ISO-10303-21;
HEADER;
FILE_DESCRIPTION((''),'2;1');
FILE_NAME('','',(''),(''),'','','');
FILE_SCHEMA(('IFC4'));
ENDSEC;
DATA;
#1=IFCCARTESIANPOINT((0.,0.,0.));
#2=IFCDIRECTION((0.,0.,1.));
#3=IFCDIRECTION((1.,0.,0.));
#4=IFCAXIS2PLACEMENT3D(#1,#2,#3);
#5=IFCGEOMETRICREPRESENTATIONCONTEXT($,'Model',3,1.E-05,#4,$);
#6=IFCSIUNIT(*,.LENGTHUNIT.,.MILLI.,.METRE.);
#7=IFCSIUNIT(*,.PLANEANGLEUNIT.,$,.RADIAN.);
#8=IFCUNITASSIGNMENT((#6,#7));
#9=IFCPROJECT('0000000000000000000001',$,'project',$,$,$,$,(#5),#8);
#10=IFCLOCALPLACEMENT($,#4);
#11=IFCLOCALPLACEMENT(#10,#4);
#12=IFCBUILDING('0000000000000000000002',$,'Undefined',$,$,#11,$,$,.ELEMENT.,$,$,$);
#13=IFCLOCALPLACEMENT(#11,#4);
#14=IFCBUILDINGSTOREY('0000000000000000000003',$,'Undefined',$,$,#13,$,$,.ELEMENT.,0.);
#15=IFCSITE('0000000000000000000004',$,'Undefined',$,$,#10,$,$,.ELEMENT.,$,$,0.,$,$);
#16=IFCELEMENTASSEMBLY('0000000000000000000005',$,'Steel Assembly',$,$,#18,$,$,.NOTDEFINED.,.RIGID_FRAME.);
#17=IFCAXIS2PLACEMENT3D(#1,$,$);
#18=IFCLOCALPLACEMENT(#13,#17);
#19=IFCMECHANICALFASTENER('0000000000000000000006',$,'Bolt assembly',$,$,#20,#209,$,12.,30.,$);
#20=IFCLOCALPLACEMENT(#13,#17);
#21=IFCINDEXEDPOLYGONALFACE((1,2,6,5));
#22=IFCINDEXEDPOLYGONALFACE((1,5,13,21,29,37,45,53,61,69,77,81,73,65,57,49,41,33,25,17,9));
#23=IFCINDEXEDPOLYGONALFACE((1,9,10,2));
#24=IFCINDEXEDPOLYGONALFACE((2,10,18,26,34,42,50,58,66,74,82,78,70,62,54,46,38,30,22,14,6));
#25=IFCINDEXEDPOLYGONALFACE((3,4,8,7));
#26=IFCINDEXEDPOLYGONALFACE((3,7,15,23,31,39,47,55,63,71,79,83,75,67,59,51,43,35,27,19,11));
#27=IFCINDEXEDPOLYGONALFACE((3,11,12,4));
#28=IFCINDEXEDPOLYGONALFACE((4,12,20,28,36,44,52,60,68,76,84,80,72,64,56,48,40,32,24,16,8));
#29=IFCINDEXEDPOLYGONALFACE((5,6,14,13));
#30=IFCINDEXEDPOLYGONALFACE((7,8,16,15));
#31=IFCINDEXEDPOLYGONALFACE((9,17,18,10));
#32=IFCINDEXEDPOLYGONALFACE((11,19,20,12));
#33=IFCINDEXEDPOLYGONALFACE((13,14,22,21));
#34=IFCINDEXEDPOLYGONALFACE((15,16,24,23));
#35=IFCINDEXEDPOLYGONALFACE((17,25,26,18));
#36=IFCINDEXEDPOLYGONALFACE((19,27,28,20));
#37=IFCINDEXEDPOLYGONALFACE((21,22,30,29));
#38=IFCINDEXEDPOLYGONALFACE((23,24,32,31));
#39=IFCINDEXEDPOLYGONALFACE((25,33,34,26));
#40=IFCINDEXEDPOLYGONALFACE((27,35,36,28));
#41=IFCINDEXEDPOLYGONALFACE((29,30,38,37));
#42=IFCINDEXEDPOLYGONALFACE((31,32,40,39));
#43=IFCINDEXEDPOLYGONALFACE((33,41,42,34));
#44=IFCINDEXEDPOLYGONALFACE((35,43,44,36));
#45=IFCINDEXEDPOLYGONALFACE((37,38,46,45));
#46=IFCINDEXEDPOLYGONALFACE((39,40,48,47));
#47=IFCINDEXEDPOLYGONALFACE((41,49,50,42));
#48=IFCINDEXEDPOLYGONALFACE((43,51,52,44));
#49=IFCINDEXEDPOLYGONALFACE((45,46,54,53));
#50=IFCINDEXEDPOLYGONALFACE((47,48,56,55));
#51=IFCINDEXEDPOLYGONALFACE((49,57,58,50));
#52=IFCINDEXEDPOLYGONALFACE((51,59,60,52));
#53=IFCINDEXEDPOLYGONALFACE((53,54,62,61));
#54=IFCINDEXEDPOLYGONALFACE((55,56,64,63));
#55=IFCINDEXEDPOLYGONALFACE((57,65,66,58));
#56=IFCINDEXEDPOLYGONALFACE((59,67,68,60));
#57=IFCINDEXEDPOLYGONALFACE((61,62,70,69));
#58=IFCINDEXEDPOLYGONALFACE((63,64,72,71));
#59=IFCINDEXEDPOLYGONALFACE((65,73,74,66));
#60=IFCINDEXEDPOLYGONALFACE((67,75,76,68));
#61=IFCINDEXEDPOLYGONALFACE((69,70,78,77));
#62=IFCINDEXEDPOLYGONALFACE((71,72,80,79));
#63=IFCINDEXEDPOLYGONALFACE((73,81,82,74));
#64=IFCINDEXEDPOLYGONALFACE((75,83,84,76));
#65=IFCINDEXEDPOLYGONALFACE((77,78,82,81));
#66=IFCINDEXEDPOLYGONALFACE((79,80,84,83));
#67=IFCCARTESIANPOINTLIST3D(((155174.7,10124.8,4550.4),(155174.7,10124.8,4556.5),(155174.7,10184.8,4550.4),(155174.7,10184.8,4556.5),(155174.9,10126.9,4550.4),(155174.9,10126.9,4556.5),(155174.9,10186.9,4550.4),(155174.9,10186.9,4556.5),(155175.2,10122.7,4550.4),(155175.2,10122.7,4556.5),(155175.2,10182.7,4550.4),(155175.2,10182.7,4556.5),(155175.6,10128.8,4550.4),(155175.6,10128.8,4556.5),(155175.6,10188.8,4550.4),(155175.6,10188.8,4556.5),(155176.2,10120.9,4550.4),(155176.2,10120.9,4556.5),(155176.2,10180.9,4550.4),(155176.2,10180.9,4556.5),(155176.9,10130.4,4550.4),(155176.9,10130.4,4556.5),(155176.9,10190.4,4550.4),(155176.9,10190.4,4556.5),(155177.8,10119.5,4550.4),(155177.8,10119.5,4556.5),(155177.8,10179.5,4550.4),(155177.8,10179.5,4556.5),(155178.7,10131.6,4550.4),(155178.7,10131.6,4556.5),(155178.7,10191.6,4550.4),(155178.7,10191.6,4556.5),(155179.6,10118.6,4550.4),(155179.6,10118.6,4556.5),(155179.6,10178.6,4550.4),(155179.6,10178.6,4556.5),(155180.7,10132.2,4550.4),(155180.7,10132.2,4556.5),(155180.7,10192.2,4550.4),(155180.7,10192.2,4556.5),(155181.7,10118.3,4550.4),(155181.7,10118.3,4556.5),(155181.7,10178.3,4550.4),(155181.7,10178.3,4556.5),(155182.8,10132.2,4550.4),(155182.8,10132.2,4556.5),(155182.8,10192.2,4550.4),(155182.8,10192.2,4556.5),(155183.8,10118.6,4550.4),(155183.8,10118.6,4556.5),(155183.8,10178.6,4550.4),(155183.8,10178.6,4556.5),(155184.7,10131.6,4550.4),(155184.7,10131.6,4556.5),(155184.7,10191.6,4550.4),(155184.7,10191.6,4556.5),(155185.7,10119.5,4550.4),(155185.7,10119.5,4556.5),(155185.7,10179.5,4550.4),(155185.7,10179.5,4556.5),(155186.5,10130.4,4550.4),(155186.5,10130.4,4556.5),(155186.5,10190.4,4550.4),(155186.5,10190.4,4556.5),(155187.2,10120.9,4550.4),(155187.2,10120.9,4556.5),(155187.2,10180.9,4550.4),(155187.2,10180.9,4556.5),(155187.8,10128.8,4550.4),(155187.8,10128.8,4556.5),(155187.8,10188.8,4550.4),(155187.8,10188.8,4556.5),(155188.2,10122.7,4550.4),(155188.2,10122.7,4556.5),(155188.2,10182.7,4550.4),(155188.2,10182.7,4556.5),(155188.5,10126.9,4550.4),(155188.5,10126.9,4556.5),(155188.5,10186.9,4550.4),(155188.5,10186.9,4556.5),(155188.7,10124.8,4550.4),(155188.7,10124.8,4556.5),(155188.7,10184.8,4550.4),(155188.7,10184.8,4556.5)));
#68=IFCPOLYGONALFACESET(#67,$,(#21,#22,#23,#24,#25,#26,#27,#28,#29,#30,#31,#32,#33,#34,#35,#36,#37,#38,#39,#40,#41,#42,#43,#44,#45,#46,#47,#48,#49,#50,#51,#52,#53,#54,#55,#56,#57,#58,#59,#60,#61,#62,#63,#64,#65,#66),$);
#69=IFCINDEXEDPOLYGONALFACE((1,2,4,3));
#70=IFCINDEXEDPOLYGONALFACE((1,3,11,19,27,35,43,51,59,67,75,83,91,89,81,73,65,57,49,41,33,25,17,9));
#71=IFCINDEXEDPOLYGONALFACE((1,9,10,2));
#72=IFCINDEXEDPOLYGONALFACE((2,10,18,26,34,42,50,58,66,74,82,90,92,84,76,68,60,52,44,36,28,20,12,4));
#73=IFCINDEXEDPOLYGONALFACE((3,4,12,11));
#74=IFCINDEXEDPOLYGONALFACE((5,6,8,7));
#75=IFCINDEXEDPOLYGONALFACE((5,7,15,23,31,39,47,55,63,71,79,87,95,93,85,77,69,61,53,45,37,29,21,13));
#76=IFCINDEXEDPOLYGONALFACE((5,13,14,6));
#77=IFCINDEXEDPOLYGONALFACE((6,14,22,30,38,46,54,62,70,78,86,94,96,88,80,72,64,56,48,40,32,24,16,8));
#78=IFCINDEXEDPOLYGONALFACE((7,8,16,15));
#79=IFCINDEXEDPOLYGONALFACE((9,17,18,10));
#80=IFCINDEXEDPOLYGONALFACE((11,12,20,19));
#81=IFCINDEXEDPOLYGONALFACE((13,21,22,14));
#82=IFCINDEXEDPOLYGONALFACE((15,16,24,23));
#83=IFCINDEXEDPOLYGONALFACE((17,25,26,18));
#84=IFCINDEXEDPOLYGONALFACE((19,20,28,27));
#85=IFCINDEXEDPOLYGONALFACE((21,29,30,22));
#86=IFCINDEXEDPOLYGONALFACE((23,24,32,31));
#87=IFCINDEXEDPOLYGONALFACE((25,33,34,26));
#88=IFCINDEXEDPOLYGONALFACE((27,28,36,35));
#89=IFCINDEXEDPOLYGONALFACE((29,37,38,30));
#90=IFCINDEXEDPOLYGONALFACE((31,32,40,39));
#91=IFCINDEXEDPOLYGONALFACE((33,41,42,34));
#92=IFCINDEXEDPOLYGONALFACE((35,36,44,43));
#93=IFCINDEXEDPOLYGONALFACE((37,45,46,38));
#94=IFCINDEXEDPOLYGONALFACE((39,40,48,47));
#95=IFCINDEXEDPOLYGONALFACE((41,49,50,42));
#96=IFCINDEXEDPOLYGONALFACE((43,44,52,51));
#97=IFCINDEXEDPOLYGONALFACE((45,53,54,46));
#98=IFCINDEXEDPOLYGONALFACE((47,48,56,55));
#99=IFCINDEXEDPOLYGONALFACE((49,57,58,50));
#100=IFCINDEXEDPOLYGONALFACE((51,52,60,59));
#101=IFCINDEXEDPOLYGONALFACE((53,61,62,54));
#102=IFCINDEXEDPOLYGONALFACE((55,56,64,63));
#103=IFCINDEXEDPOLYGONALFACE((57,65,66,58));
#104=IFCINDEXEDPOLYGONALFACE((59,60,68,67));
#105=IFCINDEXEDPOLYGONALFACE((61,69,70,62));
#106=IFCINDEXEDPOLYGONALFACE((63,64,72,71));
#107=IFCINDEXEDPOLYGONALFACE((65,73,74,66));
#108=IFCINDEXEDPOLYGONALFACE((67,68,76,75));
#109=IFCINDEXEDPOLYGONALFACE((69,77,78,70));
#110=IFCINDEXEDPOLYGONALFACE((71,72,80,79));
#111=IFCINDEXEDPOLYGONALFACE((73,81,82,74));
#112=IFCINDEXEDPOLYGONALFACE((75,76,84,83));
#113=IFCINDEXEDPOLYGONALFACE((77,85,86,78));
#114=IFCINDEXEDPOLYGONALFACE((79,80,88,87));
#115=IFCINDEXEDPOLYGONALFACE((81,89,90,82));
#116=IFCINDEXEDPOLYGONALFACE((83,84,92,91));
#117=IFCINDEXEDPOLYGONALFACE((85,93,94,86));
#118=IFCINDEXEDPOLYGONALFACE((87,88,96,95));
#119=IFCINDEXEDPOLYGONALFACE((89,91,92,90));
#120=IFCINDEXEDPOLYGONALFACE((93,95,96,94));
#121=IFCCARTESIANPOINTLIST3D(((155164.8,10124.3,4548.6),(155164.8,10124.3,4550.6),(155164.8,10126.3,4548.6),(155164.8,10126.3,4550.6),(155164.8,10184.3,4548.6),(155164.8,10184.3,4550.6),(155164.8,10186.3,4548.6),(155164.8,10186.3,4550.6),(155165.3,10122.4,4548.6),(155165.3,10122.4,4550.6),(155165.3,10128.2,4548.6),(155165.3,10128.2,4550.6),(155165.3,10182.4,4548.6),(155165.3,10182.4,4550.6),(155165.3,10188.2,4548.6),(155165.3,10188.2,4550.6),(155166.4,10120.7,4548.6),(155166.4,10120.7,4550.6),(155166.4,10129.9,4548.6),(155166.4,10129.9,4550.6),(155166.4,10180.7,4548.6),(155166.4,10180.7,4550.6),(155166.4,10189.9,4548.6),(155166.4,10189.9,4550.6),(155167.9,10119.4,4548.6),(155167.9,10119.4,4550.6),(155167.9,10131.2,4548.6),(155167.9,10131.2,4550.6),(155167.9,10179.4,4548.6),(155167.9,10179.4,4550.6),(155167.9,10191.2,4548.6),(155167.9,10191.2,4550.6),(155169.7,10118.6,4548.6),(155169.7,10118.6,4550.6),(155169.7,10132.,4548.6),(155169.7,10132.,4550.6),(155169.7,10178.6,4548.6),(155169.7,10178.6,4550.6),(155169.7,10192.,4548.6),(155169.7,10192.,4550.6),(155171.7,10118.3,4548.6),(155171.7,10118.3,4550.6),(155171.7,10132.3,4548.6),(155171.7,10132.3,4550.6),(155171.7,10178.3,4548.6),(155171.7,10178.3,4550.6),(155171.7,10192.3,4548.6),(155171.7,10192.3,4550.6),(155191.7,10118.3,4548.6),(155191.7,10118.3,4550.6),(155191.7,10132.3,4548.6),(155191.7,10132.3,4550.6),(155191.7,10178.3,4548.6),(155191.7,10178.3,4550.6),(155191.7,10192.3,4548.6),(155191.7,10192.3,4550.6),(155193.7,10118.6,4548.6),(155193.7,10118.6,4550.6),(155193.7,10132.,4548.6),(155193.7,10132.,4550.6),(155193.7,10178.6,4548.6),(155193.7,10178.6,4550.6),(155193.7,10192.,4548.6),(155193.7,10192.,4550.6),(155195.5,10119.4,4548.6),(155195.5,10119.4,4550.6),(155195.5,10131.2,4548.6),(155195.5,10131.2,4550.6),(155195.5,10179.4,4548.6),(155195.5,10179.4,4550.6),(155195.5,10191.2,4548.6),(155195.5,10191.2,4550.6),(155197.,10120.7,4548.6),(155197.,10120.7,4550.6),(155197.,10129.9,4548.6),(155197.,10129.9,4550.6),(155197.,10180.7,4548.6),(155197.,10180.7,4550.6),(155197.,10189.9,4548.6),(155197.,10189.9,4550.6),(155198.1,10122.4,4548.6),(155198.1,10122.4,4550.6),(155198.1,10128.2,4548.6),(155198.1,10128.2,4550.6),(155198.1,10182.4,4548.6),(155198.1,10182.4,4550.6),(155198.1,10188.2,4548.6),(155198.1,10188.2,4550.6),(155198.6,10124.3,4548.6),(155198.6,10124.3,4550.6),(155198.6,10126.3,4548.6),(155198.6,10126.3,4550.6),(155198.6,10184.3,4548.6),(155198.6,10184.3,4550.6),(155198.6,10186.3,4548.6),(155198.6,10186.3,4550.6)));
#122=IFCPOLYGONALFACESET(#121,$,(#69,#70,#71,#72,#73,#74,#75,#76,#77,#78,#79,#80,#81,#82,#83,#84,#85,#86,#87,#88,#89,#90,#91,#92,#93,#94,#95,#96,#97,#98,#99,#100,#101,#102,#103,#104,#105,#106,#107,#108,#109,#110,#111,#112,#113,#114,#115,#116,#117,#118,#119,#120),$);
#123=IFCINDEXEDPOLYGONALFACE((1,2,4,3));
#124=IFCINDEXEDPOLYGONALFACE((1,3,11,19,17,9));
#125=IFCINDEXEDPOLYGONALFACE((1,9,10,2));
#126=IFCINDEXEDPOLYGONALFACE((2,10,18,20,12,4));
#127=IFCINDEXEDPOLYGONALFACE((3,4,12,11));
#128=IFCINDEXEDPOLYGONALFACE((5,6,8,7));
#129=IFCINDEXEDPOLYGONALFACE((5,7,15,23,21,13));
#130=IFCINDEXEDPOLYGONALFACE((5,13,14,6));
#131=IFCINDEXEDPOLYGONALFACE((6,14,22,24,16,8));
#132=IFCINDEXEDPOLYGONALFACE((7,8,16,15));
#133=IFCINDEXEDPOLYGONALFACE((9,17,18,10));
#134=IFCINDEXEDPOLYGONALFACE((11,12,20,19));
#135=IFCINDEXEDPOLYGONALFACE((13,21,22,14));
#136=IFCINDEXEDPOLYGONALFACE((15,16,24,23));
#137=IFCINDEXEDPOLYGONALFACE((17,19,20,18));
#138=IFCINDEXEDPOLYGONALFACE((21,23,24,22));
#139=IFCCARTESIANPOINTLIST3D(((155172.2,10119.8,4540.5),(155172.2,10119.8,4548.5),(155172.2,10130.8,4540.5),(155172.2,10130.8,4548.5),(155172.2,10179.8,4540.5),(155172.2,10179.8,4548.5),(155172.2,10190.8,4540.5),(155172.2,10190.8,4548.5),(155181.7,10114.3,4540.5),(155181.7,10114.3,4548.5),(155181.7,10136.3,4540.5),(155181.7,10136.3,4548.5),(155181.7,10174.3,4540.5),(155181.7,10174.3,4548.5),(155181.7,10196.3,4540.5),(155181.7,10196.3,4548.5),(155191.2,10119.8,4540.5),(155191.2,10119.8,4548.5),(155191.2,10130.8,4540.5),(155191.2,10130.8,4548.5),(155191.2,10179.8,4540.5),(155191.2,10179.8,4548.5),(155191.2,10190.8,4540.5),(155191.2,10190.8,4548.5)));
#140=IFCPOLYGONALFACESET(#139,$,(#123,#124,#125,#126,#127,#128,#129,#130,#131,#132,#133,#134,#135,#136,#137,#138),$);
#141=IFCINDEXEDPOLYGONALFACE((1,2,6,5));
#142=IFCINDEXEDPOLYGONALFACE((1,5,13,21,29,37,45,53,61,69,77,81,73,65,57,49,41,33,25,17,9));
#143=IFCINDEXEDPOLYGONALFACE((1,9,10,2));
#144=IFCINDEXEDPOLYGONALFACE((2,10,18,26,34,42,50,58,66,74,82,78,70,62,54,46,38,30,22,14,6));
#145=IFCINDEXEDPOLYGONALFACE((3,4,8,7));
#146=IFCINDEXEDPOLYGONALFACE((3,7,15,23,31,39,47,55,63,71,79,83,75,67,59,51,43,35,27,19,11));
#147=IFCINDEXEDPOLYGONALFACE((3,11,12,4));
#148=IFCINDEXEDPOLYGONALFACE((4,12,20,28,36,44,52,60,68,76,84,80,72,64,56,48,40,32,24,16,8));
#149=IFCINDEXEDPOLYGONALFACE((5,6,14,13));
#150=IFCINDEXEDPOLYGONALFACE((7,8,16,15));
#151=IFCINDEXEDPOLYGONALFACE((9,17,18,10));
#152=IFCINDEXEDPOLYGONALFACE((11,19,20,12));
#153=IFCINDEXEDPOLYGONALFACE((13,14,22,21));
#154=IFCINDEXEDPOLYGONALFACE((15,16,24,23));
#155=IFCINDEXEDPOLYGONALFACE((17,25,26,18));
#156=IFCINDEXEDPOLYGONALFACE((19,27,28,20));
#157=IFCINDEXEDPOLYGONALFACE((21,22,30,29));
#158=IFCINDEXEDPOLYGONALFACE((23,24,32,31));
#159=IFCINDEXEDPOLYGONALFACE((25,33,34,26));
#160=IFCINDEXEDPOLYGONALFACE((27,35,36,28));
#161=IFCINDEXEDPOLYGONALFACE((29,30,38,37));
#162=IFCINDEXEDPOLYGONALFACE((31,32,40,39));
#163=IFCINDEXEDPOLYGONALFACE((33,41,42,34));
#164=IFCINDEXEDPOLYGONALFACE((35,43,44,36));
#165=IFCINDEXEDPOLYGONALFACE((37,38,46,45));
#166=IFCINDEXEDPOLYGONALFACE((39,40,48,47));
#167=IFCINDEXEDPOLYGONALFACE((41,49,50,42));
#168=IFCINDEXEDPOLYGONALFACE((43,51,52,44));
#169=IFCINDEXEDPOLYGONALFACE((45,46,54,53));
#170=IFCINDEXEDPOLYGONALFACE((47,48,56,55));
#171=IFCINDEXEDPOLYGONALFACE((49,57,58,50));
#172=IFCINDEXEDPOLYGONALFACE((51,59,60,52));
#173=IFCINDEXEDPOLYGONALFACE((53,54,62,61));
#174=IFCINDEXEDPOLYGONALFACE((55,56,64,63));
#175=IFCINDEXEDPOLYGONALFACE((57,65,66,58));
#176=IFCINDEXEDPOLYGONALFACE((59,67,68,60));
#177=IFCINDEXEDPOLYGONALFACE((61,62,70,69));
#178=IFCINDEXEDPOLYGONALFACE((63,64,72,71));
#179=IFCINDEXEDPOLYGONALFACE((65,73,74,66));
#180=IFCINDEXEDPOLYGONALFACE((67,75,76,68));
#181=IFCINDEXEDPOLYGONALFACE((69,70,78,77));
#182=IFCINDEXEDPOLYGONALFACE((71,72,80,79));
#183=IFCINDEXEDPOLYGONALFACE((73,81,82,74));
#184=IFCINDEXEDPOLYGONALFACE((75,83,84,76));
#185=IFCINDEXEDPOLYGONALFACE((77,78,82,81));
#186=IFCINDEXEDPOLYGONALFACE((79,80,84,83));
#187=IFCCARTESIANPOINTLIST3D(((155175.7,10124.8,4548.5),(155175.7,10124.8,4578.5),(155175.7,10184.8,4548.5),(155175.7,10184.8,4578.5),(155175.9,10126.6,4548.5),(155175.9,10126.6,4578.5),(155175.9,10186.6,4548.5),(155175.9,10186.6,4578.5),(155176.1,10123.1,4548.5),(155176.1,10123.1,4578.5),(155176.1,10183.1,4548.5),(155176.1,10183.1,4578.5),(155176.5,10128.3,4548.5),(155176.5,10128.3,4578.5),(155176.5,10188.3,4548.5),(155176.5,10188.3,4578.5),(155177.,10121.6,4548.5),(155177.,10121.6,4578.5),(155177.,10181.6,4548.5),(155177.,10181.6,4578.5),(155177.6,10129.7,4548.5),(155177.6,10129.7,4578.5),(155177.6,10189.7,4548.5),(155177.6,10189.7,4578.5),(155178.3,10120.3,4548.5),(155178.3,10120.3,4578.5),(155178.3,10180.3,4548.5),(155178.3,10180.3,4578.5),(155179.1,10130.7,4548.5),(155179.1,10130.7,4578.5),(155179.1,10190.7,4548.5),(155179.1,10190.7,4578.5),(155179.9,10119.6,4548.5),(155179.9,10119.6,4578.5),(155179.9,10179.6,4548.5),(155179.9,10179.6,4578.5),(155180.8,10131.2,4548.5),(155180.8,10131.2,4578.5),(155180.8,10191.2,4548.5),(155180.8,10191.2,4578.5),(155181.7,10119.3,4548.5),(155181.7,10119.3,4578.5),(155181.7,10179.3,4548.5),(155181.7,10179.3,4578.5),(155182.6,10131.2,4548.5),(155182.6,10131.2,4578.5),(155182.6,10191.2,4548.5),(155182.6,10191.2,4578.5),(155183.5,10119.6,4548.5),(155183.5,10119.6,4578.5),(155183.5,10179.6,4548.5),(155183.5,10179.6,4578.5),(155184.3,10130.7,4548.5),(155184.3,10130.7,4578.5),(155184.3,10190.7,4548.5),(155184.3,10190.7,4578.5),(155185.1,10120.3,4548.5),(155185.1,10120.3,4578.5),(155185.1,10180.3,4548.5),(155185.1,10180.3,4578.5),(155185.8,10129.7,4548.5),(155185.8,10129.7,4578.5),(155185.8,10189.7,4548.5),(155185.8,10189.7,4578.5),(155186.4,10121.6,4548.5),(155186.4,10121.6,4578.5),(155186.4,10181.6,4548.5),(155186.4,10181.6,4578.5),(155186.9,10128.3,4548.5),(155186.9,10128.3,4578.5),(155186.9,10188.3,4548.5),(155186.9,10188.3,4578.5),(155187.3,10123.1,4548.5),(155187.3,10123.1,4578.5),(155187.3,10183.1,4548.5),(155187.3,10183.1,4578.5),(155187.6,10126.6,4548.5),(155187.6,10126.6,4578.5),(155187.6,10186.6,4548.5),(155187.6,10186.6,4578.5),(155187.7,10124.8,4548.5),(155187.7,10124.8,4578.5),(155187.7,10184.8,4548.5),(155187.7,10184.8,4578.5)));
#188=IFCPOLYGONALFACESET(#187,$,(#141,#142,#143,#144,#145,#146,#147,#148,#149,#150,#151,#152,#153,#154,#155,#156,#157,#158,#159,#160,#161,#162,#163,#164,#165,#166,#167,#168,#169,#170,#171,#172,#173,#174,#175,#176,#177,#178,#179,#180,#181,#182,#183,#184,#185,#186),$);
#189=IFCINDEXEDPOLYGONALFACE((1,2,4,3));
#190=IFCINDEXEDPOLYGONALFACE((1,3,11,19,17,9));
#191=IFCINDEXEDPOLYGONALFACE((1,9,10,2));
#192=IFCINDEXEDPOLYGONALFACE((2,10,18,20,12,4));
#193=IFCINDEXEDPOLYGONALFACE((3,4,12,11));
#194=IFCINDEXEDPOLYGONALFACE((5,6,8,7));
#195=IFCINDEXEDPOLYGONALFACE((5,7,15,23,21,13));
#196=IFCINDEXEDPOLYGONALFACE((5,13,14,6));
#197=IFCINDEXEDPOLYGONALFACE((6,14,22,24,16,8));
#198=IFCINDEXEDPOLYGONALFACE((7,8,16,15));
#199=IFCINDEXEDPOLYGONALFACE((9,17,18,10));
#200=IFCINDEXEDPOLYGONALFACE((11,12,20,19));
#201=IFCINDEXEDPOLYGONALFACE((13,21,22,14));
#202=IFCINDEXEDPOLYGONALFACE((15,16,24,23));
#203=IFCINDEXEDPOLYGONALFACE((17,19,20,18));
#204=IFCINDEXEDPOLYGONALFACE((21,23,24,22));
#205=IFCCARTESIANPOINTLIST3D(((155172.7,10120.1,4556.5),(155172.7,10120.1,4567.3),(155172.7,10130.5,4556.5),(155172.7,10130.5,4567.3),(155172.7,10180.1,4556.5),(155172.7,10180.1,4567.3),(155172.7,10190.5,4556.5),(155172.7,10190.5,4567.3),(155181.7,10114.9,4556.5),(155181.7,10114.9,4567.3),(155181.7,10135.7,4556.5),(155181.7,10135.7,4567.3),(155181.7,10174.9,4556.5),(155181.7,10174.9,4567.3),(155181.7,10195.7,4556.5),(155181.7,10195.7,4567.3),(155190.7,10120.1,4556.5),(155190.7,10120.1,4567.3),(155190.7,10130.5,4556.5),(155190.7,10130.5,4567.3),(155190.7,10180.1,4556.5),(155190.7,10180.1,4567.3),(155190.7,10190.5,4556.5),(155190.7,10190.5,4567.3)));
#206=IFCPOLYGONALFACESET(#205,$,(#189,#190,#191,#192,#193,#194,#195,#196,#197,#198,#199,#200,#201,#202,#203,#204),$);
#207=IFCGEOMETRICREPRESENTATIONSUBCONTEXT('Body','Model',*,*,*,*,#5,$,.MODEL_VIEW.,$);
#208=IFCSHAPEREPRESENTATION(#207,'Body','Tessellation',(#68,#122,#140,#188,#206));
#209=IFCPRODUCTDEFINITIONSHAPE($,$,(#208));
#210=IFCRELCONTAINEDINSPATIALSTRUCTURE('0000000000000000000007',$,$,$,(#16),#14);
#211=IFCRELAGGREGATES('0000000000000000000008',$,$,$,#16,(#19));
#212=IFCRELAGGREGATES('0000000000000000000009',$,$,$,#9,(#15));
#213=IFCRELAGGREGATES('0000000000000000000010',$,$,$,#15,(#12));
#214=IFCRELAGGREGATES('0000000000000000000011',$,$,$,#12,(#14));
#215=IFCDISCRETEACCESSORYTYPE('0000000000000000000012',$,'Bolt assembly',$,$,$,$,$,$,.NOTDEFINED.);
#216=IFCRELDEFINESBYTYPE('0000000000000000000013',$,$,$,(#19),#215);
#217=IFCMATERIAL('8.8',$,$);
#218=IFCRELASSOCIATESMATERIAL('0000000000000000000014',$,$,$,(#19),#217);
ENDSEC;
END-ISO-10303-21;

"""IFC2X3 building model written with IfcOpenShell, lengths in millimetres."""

from ifc_helpers import new_model, si_unit, frame, frame_2d, origin_with_axes, origin_2d_with_axis, place, context, subcontext, project, spatial, polyline, circle_curve, parameter, trimmed, segment, composite_curve, circle, outline, extrude, source, transform, mapped, material, type_object, element, aggregate, save


model = new_model("IFC2X3")

# Units and contexts
model_context = context("Model", 3, precision=1e-05, world=origin_with_axes())
body_context = subcontext(model_context, "Body", "Model", "MODEL_VIEW")
ifc_project = project(units=[si_unit("LENGTHUNIT", "METRE", prefix="MILLI"), si_unit("PLANEANGLEUNIT", "RADIAN")], contexts=[model_context])

# Site, building, storey
site_placement = place(None, origin_with_axes())
site = spatial("IfcSite", under=ifc_project, at=site_placement, Name="Undefined", CompositionType="ELEMENT", RefElevation=0.0)
building_placement = place(site_placement, origin_with_axes())
building = spatial("IfcBuilding", under=site, at=building_placement, Name="Undefined", CompositionType="ELEMENT")
storey_placement = place(building_placement, origin_with_axes())
storey = spatial("IfcBuildingStorey", under=building, at=storey_placement, Name="Undefined", CompositionType="ELEMENT", Elevation=0.0)

# Shared definitions
discrete_accessory_type_1 = type_object("IfcDiscreteAccessoryType", Name="Bolt assembly")

# Shared definitions
ifc_material_1 = material(Name="8.8")

# Element assembly, mechanical fastener
assembly_1_placement = place(storey_placement, origin_with_axes())
assembly_1 = element("IfcElementAssembly", 1, at=assembly_1_placement, inside=storey, Name="Steel Assembly", AssemblyPlace="NOTDEFINED", PredefinedType="RIGID_FRAME")
shared_shape_1 = source(origin_with_axes(), body_context, "Body", "SweptSolid", [
    extrude(circle(Radius=7.0, at=origin_2d_with_axis()), frame((0.0, -3.1, 0.0), z_axis=(0.0, 1.0, 0.0), x_axis=(1.0, 0.0, 0.0)), (0.0, 0.0, 1.0), 6.1),
    extrude(outline(composite_curve([segment(polyline([(7.0, 10.0), (7.0, -10.0)]), True, "CONTINUOUS"), segment(trimmed(circle_curve(frame_2d((0.0, -10.0), x_axis=(1.0, 0.0)), 7.0), [parameter(0.0)], [parameter(3.1416)], False, "PARAMETER"), True, "CONTINUOUS"), segment(polyline([(-7.0, -10.0), (-7.0, 10.0)]), True, "CONTINUOUS"), segment(trimmed(circle_curve(frame_2d((0.0, 10.0), x_axis=(-1.0, 0.0)), 7.0), [parameter(0.0)], [parameter(3.1416)], False, "PARAMETER"), True, "DISCONTINUOUS")], self_intersect=False)), frame((0.0, -4.9, 0.0), z_axis=(0.0, 1.0, 0.0), x_axis=(1.0, 0.0, 0.0)), (0.0, 0.0, 1.0), 2.0),
    extrude(outline(polyline([(11.0, 0.0), (5.5, 9.5), (-5.5, 9.5), (-11.0, 0.0), (-5.5, -9.5), (5.5, -9.5), (11.0, 0.0)])), frame((0.0, -13.0, 0.0), z_axis=(0.0, 1.0, 0.0), x_axis=(1.0, 0.0, 0.0)), (0.0, 0.0, 1.0), 8.0),
    extrude(circle(Radius=6.0, at=origin_2d_with_axis()), frame((0.0, -5.0, 0.0), z_axis=(0.0, 1.0, 0.0), x_axis=(1.0, 0.0, 0.0)), (0.0, 0.0, 1.0), 30.0),
    extrude(outline(polyline([(10.4, 0.0), (5.2, 9.0), (-5.2, 9.0), (-10.4, 0.0), (-5.2, -9.0), (5.2, -9.0), (10.4, 0.0)])), frame((0.0, 3.0, 0.0), z_axis=(0.0, 1.0, 0.0), x_axis=(1.0, 0.0, 0.0)), (0.0, 0.0, 1.0), 10.8),
])
mechanical_fastener_1_placement = place(assembly_1_placement, frame((155226.7, 10230.3, 4553.5), z_axis=(-1.0, 0.0, 0.0), x_axis=(0.0, -1.0, 0.0)))
mechanical_fastener_1 = element("IfcMechanicalFastener", 2, at=mechanical_fastener_1_placement, type_object=discrete_accessory_type_1, material=ifc_material_1, Name="Bolt assembly", NominalDiameter=12.0, NominalLength=30.0, context=body_context, shape_type="MappedRepresentation", body=[
    mapped(shared_shape_1, transform((45.0, 0.0, 45.0))),
    mapped(shared_shape_1, transform((105.0, 0.0, 45.0))),
])
aggregate(assembly_1, [mechanical_fastener_1])

save(model, "model.ifc")
